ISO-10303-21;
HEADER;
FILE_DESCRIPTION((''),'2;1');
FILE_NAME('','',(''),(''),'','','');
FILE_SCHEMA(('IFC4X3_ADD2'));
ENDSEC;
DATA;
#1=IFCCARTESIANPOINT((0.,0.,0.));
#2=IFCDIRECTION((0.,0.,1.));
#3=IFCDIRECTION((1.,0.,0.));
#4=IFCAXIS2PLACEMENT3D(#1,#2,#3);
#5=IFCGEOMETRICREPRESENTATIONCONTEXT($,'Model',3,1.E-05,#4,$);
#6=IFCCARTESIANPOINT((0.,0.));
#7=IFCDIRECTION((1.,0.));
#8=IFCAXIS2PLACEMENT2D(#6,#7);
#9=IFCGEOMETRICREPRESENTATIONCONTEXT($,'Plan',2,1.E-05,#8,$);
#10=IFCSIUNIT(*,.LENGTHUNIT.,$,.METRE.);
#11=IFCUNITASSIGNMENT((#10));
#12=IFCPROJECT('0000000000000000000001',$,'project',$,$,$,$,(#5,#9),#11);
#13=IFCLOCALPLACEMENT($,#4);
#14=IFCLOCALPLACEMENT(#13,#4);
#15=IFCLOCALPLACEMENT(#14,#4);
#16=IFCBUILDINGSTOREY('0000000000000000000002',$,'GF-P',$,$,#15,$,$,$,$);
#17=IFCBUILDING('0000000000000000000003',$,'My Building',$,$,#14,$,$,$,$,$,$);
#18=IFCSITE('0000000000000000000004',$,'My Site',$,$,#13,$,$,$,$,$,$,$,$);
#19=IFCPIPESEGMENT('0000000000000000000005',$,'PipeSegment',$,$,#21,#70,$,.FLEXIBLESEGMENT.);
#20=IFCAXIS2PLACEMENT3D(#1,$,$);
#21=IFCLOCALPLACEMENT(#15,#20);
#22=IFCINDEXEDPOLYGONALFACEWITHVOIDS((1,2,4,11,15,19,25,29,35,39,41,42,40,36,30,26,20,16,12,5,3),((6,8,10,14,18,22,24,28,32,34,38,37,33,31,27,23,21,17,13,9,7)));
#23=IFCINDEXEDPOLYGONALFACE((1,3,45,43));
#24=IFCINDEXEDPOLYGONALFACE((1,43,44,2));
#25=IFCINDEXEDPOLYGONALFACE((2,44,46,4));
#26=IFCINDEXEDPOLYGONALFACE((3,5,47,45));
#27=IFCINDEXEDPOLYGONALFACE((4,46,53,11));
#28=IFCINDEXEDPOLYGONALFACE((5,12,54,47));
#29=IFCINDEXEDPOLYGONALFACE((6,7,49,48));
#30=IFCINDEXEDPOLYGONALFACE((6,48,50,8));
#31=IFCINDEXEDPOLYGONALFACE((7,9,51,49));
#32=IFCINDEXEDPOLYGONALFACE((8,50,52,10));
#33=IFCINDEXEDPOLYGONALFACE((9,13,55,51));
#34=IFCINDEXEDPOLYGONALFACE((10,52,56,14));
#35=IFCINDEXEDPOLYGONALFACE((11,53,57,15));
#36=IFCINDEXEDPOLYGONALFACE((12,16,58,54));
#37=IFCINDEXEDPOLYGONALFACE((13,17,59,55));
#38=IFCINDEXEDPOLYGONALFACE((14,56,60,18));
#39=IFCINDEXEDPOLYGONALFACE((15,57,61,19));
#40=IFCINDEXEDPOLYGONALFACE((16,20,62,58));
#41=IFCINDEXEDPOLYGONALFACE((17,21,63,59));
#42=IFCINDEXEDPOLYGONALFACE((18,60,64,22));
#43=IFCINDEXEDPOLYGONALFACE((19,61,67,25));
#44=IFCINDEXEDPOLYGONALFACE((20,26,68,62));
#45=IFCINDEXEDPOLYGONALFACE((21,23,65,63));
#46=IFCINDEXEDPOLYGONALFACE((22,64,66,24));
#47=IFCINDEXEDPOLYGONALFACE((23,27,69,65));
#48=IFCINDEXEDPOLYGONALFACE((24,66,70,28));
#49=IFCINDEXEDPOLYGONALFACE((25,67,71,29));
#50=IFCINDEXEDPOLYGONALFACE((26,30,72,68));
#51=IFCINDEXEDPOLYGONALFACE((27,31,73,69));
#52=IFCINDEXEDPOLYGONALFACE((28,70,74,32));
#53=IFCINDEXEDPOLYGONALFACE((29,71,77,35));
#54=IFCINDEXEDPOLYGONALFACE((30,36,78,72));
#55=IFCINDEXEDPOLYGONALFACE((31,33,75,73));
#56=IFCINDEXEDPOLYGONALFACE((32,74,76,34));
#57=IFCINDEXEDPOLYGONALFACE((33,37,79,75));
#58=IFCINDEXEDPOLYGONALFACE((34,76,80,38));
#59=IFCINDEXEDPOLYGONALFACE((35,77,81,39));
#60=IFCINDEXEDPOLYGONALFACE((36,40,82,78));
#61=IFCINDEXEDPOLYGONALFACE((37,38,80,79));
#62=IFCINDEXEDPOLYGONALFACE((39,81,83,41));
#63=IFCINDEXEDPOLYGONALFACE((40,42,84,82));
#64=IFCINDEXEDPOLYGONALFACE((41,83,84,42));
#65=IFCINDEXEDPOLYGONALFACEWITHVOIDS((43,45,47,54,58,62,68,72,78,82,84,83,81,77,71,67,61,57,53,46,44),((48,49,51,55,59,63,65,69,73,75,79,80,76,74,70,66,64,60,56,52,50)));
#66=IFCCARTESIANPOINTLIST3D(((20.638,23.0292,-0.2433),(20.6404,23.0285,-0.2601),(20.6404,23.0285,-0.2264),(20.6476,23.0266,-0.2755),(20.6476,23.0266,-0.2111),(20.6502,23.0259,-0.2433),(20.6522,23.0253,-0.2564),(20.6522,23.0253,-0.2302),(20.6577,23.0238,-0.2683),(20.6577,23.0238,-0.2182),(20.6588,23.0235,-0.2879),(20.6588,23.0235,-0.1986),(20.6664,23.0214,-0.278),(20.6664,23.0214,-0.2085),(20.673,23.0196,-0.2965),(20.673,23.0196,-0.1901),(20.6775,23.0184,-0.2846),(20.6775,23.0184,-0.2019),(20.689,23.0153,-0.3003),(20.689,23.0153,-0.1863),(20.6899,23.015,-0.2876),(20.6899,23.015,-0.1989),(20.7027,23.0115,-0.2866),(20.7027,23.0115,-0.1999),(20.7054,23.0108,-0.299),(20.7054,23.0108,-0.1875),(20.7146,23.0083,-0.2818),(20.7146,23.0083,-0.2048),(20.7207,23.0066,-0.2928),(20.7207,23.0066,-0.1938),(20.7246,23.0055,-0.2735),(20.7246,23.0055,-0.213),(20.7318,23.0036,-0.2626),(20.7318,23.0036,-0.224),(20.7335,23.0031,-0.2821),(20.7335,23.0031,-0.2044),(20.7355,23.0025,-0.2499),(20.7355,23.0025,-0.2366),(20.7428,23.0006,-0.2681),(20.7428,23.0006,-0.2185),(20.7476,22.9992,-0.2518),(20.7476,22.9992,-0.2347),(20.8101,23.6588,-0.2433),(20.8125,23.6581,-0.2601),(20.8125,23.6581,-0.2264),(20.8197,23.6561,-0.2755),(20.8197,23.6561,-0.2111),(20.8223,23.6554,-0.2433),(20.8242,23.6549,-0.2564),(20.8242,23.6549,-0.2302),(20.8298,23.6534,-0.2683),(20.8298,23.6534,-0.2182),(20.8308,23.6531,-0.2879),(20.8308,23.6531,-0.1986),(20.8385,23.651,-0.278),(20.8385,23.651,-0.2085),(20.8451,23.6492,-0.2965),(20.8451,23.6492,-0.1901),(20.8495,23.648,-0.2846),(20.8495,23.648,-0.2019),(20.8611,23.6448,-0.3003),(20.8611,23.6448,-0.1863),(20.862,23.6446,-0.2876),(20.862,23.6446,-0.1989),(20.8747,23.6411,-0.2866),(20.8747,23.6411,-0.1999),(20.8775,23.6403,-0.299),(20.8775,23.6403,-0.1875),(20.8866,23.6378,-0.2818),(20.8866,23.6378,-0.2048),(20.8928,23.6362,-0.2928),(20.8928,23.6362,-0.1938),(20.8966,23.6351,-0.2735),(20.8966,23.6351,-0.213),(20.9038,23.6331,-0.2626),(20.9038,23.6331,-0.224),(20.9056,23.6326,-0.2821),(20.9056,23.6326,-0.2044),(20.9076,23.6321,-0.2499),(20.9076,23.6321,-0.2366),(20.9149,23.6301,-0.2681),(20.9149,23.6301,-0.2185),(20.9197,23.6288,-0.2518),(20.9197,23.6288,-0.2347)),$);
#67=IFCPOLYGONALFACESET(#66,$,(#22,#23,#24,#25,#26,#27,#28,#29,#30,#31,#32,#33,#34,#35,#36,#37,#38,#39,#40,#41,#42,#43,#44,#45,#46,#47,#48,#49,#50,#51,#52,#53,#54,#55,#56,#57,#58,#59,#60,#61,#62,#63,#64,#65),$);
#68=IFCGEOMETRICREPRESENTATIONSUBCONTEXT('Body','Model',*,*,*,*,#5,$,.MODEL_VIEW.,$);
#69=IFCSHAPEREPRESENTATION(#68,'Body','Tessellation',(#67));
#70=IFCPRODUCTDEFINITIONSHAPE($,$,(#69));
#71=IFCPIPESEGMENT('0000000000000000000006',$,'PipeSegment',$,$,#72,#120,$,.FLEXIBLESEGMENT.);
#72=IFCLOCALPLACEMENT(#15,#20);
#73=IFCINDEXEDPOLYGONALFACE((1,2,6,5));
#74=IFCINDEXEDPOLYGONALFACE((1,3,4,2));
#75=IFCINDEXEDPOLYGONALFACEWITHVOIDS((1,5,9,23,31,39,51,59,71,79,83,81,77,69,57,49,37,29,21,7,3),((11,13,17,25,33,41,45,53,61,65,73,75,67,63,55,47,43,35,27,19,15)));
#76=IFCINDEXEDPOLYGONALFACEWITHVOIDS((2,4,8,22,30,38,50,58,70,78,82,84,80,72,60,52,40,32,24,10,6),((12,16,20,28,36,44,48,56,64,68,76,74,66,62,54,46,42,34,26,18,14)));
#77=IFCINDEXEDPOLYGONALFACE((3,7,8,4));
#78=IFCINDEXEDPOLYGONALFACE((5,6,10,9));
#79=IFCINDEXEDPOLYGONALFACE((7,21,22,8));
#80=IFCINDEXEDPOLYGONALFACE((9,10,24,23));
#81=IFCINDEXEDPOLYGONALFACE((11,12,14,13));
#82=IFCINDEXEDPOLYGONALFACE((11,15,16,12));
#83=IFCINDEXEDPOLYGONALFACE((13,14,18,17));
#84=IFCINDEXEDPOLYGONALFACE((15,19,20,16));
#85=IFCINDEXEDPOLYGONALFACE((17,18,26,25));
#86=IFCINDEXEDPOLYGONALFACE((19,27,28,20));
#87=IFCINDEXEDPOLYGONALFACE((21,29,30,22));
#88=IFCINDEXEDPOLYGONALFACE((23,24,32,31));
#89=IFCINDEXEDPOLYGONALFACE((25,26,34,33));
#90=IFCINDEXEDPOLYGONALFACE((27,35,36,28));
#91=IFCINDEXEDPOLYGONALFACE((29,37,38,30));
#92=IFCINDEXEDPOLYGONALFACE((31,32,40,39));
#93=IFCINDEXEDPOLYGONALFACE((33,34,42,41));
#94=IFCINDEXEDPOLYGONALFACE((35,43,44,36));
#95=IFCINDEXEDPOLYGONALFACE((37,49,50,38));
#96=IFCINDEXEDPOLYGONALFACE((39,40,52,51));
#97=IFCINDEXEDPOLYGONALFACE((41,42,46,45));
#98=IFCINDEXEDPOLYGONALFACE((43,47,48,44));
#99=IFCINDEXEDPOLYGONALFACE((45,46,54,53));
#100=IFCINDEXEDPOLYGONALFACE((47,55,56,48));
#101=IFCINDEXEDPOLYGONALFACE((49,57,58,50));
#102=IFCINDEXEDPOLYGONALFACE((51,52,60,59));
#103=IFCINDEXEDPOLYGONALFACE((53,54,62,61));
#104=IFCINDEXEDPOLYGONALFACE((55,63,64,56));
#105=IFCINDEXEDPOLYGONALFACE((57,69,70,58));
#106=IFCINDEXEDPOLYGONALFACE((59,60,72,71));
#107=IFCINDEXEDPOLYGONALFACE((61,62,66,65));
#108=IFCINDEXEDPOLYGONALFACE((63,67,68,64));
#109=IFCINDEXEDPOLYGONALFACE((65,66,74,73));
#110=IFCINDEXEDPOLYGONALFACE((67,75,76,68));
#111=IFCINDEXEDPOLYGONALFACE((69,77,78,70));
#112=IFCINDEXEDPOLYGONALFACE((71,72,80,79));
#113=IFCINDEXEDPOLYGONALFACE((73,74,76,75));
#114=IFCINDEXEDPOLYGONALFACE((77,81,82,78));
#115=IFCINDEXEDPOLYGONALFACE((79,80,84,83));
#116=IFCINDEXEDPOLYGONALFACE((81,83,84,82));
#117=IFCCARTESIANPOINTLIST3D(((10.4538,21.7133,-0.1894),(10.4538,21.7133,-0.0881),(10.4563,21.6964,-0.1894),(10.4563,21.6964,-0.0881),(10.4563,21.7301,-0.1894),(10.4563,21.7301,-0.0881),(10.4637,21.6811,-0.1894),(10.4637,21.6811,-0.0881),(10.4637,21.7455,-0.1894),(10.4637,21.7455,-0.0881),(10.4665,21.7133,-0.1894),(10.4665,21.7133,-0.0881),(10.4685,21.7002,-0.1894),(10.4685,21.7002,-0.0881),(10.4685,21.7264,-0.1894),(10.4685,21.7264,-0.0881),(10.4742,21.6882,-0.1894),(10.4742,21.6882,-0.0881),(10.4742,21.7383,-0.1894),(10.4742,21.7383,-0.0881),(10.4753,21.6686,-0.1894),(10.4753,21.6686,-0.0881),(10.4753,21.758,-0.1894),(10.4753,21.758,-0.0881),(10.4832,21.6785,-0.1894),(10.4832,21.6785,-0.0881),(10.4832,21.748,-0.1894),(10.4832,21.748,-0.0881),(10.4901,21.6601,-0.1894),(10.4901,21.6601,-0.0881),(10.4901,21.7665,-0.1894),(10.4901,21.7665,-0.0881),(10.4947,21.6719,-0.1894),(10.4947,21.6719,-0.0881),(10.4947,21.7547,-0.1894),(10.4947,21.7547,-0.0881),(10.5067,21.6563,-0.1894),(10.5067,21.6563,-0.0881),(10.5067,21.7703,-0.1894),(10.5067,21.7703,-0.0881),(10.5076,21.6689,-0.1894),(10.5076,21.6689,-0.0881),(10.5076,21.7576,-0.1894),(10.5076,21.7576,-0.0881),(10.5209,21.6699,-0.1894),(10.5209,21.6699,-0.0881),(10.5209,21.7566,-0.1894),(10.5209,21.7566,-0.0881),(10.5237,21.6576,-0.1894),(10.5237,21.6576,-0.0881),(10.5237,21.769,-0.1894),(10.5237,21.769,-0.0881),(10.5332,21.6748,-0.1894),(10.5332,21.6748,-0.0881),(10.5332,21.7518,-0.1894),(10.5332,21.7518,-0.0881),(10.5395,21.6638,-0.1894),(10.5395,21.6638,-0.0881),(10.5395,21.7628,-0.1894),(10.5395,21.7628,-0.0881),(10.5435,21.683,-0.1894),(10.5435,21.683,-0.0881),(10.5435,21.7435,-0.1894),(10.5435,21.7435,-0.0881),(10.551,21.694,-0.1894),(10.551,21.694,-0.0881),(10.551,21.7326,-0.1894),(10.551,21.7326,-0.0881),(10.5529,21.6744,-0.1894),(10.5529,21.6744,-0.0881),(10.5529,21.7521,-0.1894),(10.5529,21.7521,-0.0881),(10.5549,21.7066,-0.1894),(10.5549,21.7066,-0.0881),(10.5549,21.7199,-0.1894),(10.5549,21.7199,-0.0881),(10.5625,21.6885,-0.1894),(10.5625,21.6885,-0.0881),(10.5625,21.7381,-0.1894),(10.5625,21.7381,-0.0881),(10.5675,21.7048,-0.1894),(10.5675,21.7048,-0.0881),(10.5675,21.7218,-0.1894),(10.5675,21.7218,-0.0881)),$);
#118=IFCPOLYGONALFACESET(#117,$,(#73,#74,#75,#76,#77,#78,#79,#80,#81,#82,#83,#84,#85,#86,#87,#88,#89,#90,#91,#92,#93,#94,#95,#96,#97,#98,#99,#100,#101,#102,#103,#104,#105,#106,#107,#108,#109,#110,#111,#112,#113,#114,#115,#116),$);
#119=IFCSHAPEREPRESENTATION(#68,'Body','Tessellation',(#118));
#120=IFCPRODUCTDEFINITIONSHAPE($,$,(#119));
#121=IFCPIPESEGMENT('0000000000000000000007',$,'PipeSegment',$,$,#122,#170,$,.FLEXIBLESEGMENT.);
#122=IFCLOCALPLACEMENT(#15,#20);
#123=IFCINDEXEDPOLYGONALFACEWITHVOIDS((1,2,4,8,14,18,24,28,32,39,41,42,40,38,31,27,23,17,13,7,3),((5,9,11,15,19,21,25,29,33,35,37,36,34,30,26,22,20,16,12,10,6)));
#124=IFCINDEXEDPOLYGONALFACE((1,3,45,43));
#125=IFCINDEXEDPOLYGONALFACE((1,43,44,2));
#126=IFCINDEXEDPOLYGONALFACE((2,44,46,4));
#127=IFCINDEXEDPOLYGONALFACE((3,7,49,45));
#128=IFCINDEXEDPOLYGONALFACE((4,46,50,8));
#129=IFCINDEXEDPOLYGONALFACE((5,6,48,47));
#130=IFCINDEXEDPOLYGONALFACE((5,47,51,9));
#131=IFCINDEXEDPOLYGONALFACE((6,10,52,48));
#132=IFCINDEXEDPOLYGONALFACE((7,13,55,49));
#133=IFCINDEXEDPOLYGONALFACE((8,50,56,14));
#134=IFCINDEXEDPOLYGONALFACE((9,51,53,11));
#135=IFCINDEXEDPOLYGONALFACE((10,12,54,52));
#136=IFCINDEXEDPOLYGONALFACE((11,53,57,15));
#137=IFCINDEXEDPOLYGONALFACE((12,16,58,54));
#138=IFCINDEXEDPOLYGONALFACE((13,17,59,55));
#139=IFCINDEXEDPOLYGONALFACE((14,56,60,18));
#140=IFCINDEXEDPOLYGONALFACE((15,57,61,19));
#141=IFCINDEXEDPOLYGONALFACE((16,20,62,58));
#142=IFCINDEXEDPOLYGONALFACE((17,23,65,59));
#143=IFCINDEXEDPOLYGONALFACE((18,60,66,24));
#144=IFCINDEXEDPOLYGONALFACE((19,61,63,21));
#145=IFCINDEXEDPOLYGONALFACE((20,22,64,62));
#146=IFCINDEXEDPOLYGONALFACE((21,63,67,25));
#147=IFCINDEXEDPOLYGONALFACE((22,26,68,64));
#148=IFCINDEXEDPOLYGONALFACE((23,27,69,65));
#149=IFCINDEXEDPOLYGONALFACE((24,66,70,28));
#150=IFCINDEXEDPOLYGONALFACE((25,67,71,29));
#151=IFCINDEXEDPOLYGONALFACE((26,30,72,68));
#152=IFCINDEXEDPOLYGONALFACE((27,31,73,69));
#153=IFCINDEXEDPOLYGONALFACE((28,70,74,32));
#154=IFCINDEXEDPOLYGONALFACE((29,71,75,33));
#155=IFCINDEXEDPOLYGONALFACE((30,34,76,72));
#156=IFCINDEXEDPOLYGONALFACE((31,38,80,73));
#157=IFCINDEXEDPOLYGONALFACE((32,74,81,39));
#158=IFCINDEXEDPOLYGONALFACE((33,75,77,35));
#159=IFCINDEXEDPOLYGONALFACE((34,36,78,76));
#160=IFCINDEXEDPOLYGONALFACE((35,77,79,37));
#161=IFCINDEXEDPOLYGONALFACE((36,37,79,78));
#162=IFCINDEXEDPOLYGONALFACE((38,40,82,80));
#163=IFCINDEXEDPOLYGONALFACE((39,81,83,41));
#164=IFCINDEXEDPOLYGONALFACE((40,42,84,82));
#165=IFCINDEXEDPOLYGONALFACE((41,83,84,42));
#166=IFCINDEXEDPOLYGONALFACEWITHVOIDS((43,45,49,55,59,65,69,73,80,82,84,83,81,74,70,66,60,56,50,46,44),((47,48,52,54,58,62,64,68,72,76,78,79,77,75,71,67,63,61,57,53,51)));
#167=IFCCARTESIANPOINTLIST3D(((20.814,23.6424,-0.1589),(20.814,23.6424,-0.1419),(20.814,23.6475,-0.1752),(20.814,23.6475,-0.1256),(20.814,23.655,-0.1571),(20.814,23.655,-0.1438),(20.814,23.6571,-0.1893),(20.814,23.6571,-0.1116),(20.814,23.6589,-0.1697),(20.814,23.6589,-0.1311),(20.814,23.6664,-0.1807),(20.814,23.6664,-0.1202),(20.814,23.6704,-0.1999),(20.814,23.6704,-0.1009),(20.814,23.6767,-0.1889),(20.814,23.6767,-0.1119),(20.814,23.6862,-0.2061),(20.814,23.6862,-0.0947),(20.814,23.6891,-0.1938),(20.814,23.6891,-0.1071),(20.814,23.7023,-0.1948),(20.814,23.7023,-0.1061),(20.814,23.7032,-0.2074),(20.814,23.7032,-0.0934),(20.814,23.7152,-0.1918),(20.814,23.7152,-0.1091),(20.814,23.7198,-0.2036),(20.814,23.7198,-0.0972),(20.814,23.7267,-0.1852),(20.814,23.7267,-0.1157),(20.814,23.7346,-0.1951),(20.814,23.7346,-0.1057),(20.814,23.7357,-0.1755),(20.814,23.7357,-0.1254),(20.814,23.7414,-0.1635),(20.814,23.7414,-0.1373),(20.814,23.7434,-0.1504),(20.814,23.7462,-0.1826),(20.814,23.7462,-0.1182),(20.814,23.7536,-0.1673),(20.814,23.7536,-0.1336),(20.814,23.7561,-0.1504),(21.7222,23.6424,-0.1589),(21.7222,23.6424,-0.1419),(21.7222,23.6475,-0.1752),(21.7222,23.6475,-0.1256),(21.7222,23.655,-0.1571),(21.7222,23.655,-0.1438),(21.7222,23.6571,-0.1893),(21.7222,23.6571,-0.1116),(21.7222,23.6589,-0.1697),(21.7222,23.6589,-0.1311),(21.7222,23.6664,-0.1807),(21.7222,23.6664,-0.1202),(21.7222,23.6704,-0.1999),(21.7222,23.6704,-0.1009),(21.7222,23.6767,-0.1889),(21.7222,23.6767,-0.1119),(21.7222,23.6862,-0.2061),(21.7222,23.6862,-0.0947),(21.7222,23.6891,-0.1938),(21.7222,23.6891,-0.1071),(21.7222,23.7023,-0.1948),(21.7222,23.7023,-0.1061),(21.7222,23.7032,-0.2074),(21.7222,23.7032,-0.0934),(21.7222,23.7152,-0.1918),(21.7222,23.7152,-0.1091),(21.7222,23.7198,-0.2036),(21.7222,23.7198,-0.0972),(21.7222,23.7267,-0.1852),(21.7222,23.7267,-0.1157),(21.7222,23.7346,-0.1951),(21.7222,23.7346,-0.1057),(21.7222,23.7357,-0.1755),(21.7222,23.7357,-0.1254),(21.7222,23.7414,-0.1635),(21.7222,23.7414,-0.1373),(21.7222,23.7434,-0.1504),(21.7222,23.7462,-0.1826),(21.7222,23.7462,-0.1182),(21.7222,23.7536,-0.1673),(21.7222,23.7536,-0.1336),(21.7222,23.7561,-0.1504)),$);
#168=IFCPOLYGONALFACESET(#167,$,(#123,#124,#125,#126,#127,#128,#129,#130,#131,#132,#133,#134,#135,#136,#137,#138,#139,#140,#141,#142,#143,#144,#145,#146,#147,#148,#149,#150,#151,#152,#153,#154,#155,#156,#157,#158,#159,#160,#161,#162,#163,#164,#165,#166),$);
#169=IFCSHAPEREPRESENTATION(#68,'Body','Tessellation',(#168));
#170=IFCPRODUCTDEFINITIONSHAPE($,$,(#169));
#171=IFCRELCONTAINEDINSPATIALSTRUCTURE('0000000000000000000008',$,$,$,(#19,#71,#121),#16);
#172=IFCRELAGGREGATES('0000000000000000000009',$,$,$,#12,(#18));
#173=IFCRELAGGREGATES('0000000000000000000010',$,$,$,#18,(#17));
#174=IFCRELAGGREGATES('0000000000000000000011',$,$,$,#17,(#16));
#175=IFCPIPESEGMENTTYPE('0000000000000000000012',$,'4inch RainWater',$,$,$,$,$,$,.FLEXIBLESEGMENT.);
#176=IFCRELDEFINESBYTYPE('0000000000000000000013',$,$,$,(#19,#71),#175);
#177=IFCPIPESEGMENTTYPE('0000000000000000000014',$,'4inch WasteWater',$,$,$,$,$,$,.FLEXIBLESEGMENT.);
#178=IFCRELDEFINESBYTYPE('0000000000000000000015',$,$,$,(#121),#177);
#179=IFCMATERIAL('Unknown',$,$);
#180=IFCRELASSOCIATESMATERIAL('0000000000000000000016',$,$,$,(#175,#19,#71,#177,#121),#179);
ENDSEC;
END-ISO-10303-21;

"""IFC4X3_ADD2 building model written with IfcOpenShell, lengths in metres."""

from ifc_helpers import new_model, si_unit, frame, origin_with_axes, origin_2d_with_axis, place, context, subcontext, project, spatial, hollow_circle, extrude, material, material_profile, profile_set, profile_usage, type_object, element, save


model = new_model("IFC4X3_ADD2")

# Units and contexts
model_context = context("Model", 3, precision=1e-05, world=origin_with_axes())
plan_context = context("Plan", 2, precision=1e-05, world=origin_2d_with_axis())
body_context = subcontext(model_context, "Body", "Model", "MODEL_VIEW")
ifc_project = project(units=[si_unit("LENGTHUNIT", "METRE")], contexts=[model_context, plan_context])

# Site, building, storey
site_placement = place(None, origin_with_axes())
site = spatial("IfcSite", under=ifc_project, at=site_placement, Name="My Site")
building_placement = place(site_placement, origin_with_axes())
building = spatial("IfcBuilding", under=site, at=building_placement, Name="My Building")
storey_placement = place(building_placement, origin_with_axes())
storey = spatial("IfcBuildingStorey", under=building, at=storey_placement, Name="GF-P")

# Shared definitions
ifc_material_1 = material(Name="Unknown")

# Pipe segments
ifc_material_profile_1 = material_profile(ifc_material_1, hollow_circle(Radius=0.0571, WallThickness=0.0127))
ifc_profile_set_1 = profile_set([ifc_material_profile_1], Name="rainwater")
pipe_segment_type_1 = type_object("IfcPipeSegmentType", Name="4inch RainWater", PredefinedType="FLEXIBLESEGMENT", material=ifc_profile_set_1)
ifc_profile_usage_1 = profile_usage(ifc_profile_set_1)
pipe_segment_1_placement = place(storey_placement, frame((20.6931, 23.0141, -0.2433), z_axis=(0.263659, 0.964616, 0.0), x_axis=(-0.964616, 0.263659, 0.0)))
element("IfcPipeSegment", 1, at=pipe_segment_1_placement, inside=storey, type_object=pipe_segment_type_1, material=ifc_profile_usage_1, Name="PipeSegment", PredefinedType="FLEXIBLESEGMENT", context=body_context, shape_type="SweptSolid", body=[
    extrude(hollow_circle(Radius=0.0571, WallThickness=0.0127), origin_with_axes(), (0.0, 0.0, 1.0), 0.6527),
])
ifc_profile_usage_2 = profile_usage(ifc_profile_set_1)
pipe_segment_2_placement = place(storey_placement, frame((10.511, 21.7133, -0.1894), z_axis=(0.0, 0.0, 1.0), x_axis=(-1.0, 0.0, 0.0)))
element("IfcPipeSegment", 2, at=pipe_segment_2_placement, inside=storey, type_object=pipe_segment_type_1, material=ifc_profile_usage_2, Name="PipeSegment", PredefinedType="FLEXIBLESEGMENT", context=body_context, shape_type="SweptSolid", body=[
    extrude(hollow_circle(Radius=0.0571, WallThickness=0.0127), origin_with_axes(), (0.0, 0.0, 1.0), 0.1013),
])
ifc_material_profile_2 = material_profile(ifc_material_1, hollow_circle(Radius=0.0571, WallThickness=0.0127))
ifc_profile_set_2 = profile_set([ifc_material_profile_2], Name="wastewater")
ifc_profile_usage_3 = profile_usage(ifc_profile_set_2)
pipe_segment_type_2 = type_object("IfcPipeSegmentType", Name="4inch WasteWater", PredefinedType="FLEXIBLESEGMENT", material=ifc_profile_set_2)
pipe_segment_3_placement = place(storey_placement, frame((20.814, 23.699, -0.1504), z_axis=(1.0, 0.0, 0.0), x_axis=(0.0, 1.0, 0.0)))
element("IfcPipeSegment", 3, at=pipe_segment_3_placement, inside=storey, type_object=pipe_segment_type_2, material=ifc_profile_usage_3, Name="PipeSegment", PredefinedType="FLEXIBLESEGMENT", context=body_context, shape_type="SweptSolid", body=[
    extrude(hollow_circle(Radius=0.0571, WallThickness=0.0127), origin_with_axes(), (0.0, 0.0, 1.0), 0.9083),
])

save(model, "model.ifc")
